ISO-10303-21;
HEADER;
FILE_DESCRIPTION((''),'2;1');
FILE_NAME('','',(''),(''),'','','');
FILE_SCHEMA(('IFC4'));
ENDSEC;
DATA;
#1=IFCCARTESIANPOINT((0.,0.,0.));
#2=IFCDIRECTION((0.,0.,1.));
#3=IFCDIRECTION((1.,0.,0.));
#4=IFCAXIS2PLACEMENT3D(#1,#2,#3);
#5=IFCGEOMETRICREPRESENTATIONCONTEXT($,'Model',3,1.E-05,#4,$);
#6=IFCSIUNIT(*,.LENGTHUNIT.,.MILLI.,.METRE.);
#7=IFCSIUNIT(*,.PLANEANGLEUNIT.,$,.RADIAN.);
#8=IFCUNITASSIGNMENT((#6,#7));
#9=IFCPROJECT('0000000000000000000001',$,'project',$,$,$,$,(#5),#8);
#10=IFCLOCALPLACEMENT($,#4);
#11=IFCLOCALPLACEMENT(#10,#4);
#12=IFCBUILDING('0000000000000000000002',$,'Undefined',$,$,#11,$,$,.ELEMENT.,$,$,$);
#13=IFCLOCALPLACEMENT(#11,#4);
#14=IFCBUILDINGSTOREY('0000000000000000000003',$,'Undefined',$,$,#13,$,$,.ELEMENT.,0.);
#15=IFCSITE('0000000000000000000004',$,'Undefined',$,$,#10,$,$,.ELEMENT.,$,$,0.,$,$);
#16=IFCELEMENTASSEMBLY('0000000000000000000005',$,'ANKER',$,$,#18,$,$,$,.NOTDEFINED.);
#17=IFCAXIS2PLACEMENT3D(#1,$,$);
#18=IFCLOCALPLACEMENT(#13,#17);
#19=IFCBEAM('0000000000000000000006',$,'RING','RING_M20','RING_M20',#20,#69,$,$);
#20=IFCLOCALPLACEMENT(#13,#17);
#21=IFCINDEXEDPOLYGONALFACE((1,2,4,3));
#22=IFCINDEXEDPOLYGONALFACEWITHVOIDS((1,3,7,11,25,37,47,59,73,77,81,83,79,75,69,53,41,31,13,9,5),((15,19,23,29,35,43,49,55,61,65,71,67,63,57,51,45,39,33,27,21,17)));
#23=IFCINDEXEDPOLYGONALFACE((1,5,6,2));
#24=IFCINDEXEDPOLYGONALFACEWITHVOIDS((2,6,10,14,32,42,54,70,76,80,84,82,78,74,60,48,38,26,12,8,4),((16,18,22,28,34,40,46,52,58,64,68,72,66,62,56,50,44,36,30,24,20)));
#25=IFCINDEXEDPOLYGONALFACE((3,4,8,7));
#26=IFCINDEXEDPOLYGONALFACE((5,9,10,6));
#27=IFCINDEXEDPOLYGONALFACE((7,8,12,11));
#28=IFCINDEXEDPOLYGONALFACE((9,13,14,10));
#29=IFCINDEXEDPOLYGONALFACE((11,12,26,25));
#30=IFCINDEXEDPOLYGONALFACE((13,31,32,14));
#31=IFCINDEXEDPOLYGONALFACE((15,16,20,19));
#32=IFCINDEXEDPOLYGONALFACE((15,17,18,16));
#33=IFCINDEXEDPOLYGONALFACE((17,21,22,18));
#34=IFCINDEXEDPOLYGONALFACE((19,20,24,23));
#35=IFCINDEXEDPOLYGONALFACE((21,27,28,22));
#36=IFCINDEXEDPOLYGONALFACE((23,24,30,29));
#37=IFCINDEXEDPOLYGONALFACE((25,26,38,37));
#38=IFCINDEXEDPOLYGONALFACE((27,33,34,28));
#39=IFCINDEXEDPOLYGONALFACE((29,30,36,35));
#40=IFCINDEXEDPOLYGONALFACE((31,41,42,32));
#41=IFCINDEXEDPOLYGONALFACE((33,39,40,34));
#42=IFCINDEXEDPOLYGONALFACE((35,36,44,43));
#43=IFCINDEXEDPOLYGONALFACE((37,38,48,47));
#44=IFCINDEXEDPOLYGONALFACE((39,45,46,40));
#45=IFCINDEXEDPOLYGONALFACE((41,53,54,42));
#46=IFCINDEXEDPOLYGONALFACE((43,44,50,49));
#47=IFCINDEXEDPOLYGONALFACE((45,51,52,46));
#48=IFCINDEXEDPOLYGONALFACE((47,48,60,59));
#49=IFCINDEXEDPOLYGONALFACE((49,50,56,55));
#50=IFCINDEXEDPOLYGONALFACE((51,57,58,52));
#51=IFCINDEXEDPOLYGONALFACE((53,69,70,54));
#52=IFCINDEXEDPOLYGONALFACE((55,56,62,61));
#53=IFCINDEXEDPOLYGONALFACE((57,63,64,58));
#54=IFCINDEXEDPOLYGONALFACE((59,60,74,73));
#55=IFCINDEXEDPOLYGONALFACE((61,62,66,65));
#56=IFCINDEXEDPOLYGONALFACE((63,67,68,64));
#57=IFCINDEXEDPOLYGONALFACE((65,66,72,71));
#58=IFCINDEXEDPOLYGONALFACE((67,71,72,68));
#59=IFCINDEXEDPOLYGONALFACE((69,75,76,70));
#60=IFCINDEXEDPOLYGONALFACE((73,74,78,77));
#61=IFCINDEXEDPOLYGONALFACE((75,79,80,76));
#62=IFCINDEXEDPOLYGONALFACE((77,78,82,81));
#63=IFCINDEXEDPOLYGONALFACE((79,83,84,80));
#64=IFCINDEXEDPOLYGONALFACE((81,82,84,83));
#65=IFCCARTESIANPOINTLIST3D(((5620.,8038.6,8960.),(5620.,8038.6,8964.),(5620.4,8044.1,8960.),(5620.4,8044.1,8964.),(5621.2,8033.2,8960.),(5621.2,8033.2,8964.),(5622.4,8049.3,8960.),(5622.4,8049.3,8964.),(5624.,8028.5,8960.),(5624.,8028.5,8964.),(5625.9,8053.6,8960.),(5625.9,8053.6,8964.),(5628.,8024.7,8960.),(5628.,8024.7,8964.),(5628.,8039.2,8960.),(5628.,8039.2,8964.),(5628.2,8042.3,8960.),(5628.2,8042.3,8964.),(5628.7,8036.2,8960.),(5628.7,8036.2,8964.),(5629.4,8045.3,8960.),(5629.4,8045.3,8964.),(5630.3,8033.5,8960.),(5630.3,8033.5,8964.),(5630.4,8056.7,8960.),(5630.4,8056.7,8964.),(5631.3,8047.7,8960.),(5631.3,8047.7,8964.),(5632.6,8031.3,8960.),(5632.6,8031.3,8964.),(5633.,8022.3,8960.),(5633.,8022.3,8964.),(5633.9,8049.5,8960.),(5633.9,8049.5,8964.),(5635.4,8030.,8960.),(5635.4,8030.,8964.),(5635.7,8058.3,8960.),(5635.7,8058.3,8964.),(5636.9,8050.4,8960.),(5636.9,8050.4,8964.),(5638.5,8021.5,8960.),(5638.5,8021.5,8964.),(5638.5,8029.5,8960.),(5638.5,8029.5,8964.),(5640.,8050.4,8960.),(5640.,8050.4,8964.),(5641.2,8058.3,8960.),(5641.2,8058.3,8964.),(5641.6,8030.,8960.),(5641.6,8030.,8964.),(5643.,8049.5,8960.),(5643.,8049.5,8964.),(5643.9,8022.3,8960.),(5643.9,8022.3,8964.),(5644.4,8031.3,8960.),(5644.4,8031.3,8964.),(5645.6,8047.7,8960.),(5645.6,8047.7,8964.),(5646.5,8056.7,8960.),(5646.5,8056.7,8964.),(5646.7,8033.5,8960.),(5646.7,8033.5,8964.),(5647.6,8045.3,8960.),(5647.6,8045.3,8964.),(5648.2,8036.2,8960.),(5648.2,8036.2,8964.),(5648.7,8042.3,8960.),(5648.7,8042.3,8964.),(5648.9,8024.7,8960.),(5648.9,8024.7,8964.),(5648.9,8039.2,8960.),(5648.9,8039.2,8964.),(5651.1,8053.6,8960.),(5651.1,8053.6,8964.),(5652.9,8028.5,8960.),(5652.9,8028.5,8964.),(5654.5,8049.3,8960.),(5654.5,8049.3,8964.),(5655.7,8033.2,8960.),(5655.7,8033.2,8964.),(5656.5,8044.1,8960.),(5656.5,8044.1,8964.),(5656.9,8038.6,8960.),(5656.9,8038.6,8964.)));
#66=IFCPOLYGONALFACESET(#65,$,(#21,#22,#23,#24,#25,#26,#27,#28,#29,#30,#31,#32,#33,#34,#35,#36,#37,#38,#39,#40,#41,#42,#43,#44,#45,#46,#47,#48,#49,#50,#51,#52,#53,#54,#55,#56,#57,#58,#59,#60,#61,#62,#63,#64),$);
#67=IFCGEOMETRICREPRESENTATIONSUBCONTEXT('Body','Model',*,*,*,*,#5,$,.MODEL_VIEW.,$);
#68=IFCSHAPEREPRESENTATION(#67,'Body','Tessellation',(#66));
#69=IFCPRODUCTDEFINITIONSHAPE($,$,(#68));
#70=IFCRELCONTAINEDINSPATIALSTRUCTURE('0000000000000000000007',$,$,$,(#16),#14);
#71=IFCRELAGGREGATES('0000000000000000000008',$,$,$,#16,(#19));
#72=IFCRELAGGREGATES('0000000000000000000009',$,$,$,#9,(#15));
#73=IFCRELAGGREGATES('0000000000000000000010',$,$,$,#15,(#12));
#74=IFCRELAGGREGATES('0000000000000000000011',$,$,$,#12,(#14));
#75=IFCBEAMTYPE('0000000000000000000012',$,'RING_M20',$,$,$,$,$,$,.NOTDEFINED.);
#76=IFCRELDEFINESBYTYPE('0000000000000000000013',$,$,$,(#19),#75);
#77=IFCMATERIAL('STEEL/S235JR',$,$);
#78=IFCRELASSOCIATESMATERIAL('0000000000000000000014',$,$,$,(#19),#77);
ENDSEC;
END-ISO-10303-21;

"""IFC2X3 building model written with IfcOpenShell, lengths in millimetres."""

from ifc_helpers import new_model, si_unit, frame, origin_with_axes, origin_2d_with_axis, place, context, subcontext, project, spatial, hollow_circle, extrude, material, type_object, element, aggregate, save


model = new_model("IFC2X3")

# Units and contexts
model_context = context("Model", 3, precision=1e-05, world=origin_with_axes())
body_context = subcontext(model_context, "Body", "Model", "MODEL_VIEW")
ifc_project = project(units=[si_unit("LENGTHUNIT", "METRE", prefix="MILLI"), si_unit("PLANEANGLEUNIT", "RADIAN")], contexts=[model_context])

# Site, building, storey
site_placement = place(None, origin_with_axes())
site = spatial("IfcSite", under=ifc_project, at=site_placement, Name="Undefined", CompositionType="ELEMENT", RefElevation=0.0)
building_placement = place(site_placement, origin_with_axes())
building = spatial("IfcBuilding", under=site, at=building_placement, Name="Undefined", CompositionType="ELEMENT")
storey_placement = place(building_placement, origin_with_axes())
storey = spatial("IfcBuildingStorey", under=building, at=storey_placement, Name="Undefined", CompositionType="ELEMENT", Elevation=0.0)

# Shared definitions
ifc_material = material(Name="STEEL/S235JR")

# Shared definitions
beam_type_1 = type_object("IfcBeamType", Name="RING_M20", PredefinedType="NOTDEFINED")

# Element assembly, beam
assembly_1_placement = place(storey_placement, frame((5638.5, 8040.0, 9010.0), z_axis=(0.0, 1.0, 0.0), x_axis=(0.0, 0.0, -1.0)))
assembly_1 = element("IfcElementAssembly", 1, at=assembly_1_placement, inside=storey, Name="ANKER", PredefinedType="NOTDEFINED")
beam_1_placement = place(storey_placement, frame((5638.5, 8040.0, 8964.0), z_axis=(1.0, 0.0, 0.0), x_axis=(0.0, 0.0, -1.0)))
beam_1 = element("IfcBeam", 2, at=beam_1_placement, type_object=beam_type_1, material=ifc_material, Name="RING", Description="RING_M20", ObjectType="RING_M20", context=body_context, shape_type="SweptSolid", body=[
    extrude(hollow_circle(Radius=18.5, WallThickness=8.0, at=origin_2d_with_axis()), frame((4.0, 0.0, 0.0), z_axis=(-1.0, 0.0, 0.0), x_axis=(0.0, -1.0, 0.0)), (0.0, 0.0, 1.0), 4.0),
])
aggregate(assembly_1, [beam_1])

save(model, "model.ifc")
